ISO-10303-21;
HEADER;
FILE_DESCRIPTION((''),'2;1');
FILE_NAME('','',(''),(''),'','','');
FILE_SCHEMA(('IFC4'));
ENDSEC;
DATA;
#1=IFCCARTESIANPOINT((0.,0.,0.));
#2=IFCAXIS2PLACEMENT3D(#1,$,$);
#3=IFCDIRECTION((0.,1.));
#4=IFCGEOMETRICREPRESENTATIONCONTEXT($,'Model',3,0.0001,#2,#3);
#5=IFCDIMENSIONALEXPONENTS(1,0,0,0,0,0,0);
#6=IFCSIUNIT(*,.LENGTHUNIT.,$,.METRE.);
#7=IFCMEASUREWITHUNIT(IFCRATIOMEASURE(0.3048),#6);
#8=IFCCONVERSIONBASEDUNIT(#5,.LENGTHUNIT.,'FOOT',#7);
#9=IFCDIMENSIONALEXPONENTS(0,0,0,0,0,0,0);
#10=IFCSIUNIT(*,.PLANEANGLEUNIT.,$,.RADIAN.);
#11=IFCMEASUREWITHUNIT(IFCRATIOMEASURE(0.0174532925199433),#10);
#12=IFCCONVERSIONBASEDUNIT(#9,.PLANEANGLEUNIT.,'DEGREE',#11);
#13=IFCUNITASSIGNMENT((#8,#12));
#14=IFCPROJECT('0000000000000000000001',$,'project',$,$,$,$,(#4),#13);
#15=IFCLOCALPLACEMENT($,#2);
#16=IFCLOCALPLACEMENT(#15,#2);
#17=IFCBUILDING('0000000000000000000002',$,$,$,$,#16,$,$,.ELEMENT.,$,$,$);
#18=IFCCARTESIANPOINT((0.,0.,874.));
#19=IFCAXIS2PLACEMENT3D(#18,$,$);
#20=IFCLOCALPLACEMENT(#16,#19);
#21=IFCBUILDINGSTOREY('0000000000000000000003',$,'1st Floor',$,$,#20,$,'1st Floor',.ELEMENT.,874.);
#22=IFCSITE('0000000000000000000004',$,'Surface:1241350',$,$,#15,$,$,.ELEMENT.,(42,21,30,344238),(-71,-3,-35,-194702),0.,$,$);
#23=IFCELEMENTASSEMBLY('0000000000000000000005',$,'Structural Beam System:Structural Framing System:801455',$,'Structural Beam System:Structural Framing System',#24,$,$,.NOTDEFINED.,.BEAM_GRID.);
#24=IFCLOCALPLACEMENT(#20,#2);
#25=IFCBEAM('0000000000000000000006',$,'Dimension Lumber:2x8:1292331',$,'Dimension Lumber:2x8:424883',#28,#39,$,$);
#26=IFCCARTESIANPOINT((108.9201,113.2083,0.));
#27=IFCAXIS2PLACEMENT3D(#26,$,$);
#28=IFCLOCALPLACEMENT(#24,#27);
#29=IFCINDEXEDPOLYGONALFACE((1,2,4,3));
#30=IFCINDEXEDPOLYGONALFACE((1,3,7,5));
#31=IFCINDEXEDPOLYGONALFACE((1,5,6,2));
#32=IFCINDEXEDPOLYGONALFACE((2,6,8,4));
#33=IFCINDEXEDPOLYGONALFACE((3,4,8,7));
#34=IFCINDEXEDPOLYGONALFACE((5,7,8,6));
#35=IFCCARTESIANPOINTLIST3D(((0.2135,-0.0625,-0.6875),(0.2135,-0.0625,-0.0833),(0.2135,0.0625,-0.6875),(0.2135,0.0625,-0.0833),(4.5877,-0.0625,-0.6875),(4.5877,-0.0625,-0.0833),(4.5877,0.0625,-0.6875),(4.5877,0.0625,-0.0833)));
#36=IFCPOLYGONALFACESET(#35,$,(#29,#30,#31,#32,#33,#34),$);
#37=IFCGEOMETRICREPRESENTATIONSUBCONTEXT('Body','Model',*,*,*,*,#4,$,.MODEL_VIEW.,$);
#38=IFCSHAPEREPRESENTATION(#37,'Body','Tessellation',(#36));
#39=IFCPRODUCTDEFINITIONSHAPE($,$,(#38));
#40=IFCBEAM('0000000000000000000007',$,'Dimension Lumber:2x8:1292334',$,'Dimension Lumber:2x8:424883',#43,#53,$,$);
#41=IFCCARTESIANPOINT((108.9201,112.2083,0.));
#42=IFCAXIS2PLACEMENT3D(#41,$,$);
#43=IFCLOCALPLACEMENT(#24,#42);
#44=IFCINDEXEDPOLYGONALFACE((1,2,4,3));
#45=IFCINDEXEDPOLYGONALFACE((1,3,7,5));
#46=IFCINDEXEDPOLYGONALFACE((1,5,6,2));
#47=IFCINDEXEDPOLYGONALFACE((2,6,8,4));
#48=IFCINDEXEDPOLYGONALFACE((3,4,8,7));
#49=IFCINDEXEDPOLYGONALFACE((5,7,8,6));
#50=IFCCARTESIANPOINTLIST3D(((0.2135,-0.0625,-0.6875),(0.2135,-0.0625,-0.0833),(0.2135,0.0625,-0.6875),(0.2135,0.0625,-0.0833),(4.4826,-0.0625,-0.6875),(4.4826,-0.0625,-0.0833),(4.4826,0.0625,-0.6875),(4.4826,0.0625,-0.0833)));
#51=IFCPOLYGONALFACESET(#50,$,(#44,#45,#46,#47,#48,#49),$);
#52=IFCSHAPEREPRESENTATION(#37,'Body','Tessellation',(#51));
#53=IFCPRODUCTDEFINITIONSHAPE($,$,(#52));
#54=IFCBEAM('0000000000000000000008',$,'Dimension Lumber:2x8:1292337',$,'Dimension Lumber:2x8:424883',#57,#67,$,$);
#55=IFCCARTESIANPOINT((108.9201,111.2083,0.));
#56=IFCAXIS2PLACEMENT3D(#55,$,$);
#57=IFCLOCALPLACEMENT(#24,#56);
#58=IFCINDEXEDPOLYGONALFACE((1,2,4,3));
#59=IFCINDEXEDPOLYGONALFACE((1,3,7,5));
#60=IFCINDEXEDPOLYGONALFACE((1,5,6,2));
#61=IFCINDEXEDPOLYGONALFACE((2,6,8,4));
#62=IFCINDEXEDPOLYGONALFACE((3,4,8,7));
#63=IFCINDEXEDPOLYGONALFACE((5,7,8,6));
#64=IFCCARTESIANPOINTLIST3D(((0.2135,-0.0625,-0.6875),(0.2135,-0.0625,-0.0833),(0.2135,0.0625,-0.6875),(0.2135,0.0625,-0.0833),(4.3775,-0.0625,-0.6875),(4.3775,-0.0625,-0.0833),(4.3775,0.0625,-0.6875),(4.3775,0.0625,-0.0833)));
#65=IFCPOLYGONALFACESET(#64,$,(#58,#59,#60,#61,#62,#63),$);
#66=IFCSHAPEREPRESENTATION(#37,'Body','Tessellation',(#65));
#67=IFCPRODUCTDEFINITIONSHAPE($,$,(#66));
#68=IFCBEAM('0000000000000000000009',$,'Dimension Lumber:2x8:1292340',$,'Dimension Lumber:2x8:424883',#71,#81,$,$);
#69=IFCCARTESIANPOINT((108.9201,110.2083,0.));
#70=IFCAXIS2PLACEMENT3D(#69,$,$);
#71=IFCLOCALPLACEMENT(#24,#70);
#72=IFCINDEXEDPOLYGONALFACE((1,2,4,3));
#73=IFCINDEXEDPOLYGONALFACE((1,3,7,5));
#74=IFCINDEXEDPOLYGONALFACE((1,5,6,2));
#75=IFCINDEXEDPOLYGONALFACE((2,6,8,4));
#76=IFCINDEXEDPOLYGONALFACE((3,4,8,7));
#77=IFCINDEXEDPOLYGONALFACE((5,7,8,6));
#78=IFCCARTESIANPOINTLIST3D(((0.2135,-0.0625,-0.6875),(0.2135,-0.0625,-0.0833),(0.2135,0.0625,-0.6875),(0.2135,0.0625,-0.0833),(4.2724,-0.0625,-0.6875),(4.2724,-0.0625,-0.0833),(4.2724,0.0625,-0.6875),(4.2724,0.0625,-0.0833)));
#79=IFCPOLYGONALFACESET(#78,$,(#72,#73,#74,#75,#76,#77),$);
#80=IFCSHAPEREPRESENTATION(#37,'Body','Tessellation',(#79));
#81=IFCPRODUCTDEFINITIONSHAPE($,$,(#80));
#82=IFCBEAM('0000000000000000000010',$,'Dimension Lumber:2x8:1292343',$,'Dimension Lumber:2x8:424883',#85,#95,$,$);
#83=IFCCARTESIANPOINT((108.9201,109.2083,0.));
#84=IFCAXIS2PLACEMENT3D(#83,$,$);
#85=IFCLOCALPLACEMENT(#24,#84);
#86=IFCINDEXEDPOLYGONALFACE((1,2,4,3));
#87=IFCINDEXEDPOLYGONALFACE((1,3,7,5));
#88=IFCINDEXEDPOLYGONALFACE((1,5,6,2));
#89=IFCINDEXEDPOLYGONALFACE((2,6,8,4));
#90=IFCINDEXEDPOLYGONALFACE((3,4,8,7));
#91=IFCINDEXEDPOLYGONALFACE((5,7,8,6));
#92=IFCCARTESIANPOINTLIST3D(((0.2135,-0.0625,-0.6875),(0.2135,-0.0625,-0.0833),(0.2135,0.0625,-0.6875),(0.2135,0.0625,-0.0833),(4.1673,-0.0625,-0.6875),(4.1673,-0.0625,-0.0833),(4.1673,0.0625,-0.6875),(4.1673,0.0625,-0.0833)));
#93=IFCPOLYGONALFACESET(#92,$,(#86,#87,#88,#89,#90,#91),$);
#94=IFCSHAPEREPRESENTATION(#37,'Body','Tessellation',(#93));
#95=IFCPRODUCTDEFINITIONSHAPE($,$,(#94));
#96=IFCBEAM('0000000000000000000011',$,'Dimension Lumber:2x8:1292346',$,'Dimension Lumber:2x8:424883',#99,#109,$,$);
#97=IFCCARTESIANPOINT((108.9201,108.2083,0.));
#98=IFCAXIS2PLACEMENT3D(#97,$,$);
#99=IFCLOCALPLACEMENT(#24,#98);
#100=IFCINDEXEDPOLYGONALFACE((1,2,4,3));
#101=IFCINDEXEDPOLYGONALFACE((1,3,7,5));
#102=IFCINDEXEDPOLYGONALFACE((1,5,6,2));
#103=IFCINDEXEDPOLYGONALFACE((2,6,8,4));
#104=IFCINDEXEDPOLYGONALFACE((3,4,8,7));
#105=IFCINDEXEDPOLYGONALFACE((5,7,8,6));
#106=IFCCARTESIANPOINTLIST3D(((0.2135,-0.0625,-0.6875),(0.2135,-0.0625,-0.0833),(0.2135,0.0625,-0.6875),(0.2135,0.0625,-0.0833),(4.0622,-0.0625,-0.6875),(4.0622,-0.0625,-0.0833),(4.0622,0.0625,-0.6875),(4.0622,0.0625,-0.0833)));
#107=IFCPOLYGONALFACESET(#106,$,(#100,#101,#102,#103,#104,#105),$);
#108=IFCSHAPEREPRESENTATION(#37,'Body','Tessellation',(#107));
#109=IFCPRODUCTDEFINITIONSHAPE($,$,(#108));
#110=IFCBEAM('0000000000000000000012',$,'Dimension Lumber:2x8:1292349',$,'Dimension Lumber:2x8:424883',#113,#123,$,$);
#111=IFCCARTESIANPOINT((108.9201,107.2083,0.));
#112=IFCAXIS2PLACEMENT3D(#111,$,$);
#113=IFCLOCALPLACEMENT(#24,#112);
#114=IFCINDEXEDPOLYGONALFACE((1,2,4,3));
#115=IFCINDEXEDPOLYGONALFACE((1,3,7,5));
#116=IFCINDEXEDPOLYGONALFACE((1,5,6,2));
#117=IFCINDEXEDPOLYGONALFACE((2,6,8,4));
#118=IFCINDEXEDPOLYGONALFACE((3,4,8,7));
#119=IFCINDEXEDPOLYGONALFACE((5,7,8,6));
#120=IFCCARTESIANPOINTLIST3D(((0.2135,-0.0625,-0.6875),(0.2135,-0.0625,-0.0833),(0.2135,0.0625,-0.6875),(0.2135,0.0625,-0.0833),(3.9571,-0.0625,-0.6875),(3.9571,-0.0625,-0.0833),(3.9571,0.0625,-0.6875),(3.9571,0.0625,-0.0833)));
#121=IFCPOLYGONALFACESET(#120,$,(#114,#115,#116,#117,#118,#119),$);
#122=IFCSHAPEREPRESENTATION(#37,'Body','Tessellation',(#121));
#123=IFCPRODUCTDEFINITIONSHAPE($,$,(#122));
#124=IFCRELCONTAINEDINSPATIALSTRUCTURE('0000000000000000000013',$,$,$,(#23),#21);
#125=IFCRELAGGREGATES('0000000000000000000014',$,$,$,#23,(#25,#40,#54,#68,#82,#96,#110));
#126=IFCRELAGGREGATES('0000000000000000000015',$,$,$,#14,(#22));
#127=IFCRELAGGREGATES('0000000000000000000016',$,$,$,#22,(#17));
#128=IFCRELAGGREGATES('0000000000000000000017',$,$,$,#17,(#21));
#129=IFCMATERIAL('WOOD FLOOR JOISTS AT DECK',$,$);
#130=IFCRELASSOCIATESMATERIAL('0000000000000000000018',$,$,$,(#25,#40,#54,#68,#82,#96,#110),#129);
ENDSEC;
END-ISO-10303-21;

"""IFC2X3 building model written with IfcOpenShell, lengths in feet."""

from ifc_helpers import new_model, entity, si_unit, converted_unit, direction, frame, origin, origin_2d_with_axis, place, context, subcontext, project, spatial, rectangle, extrude, material, element, aggregate, save


model = new_model("IFC2X3")

# Units and contexts
model_context = context("Model", 3, precision=0.0001, world=origin(), true_north=direction((0.0, 1.0)))
body_context = subcontext(model_context, "Body", "Model", "MODEL_VIEW")
ifc_project = project(units=[converted_unit("LENGTHUNIT", "FOOT", entity("IfcRatioMeasure", 0.3048), si_unit("LENGTHUNIT", "METRE"), dimensions=[1, 0, 0, 0, 0, 0, 0]), converted_unit("PLANEANGLEUNIT", "DEGREE", entity("IfcRatioMeasure", 0.0174532925199433), si_unit("PLANEANGLEUNIT", "RADIAN"), dimensions=[0, 0, 0, 0, 0, 0, 0])], contexts=[model_context])

# Site, building, storey
site_placement = place(None, origin())
site = spatial("IfcSite", under=ifc_project, at=site_placement, Name="Surface:1241350", CompositionType="ELEMENT", RefLatitude=(42, 21, 30, 344238), RefLongitude=(-71, -3, -35, -194702), RefElevation=0.0)
building_placement = place(site_placement, origin())
building = spatial("IfcBuilding", under=site, at=building_placement, CompositionType="ELEMENT")
storey_placement = place(building_placement, frame((0.0, 0.0, 874.0)))
storey = spatial("IfcBuildingStorey", under=building, at=storey_placement, Name="1st Floor", LongName="1st Floor", CompositionType="ELEMENT", Elevation=874.0)

# Element assembly, beams
assembly_placement = place(storey_placement, origin())
assembly = element("IfcElementAssembly", 1, at=assembly_placement, inside=storey, Name="Structural Beam System:Structural Framing System:801455", ObjectType="Structural Beam System:Structural Framing System", AssemblyPlace="NOTDEFINED", PredefinedType="BEAM_GRID")
ifc_material_1 = material(Name="WOOD FLOOR JOISTS AT DECK")
beam_1_placement = place(assembly_placement, frame((108.9201, 113.2083, 0.0)))
beam_1 = element("IfcBeam", 2, at=beam_1_placement, material=ifc_material_1, Name="Dimension Lumber:2x8:1292331", ObjectType="Dimension Lumber:2x8:424883", context=body_context, shape_type="SweptSolid", body=[
    extrude(rectangle(XDim=0.6042, YDim=0.125, at=origin_2d_with_axis()), frame((0.2135, 0.0, -0.3854), z_axis=(1.0, 0.0, 0.0), x_axis=(0.0, 0.0, -1.0)), (0.0, 0.0, 1.0), 4.3742),
])
beam_2_placement = place(assembly_placement, frame((108.9201, 112.2083, 0.0)))
beam_2 = element("IfcBeam", 3, at=beam_2_placement, material=ifc_material_1, Name="Dimension Lumber:2x8:1292334", ObjectType="Dimension Lumber:2x8:424883", context=body_context, shape_type="SweptSolid", body=[
    extrude(rectangle(XDim=0.6042, YDim=0.125, at=origin_2d_with_axis()), frame((0.2135, 0.0, -0.3854), z_axis=(1.0, 0.0, 0.0), x_axis=(0.0, 0.0, -1.0)), (0.0, 0.0, 1.0), 4.2691),
])
beam_3_placement = place(assembly_placement, frame((108.9201, 111.2083, 0.0)))
beam_3 = element("IfcBeam", 4, at=beam_3_placement, material=ifc_material_1, Name="Dimension Lumber:2x8:1292337", ObjectType="Dimension Lumber:2x8:424883", context=body_context, shape_type="SweptSolid", body=[
    extrude(rectangle(XDim=0.6042, YDim=0.125, at=origin_2d_with_axis()), frame((0.2135, 0.0, -0.3854), z_axis=(1.0, 0.0, 0.0), x_axis=(0.0, 0.0, -1.0)), (0.0, 0.0, 1.0), 4.1639),
])
beam_4_placement = place(assembly_placement, frame((108.9201, 110.2083, 0.0)))
beam_4 = element("IfcBeam", 5, at=beam_4_placement, material=ifc_material_1, Name="Dimension Lumber:2x8:1292340", ObjectType="Dimension Lumber:2x8:424883", context=body_context, shape_type="SweptSolid", body=[
    extrude(rectangle(XDim=0.6042, YDim=0.125, at=origin_2d_with_axis()), frame((0.2135, 0.0, -0.3854), z_axis=(1.0, 0.0, 0.0), x_axis=(0.0, 0.0, -1.0)), (0.0, 0.0, 1.0), 4.0588),
])
beam_5_placement = place(assembly_placement, frame((108.9201, 109.2083, 0.0)))
beam_5 = element("IfcBeam", 6, at=beam_5_placement, material=ifc_material_1, Name="Dimension Lumber:2x8:1292343", ObjectType="Dimension Lumber:2x8:424883", context=body_context, shape_type="SweptSolid", body=[
    extrude(rectangle(XDim=0.6042, YDim=0.125, at=origin_2d_with_axis()), frame((0.2135, 0.0, -0.3854), z_axis=(1.0, 0.0, 0.0), x_axis=(0.0, 0.0, -1.0)), (0.0, 0.0, 1.0), 3.9537),
])
beam_6_placement = place(assembly_placement, frame((108.9201, 108.2083, 0.0)))
beam_6 = element("IfcBeam", 7, at=beam_6_placement, material=ifc_material_1, Name="Dimension Lumber:2x8:1292346", ObjectType="Dimension Lumber:2x8:424883", context=body_context, shape_type="SweptSolid", body=[
    extrude(rectangle(XDim=0.6042, YDim=0.125, at=origin_2d_with_axis()), frame((0.2135, 0.0, -0.3854), z_axis=(1.0, 0.0, 0.0), x_axis=(0.0, 0.0, -1.0)), (0.0, 0.0, 1.0), 3.8486),
])
beam_7_placement = place(assembly_placement, frame((108.9201, 107.2083, 0.0)))
beam_7 = element("IfcBeam", 8, at=beam_7_placement, material=ifc_material_1, Name="Dimension Lumber:2x8:1292349", ObjectType="Dimension Lumber:2x8:424883", context=body_context, shape_type="SweptSolid", body=[
    extrude(rectangle(XDim=0.6042, YDim=0.125, at=origin_2d_with_axis()), frame((0.2135, 0.0, -0.3854), z_axis=(1.0, 0.0, 0.0), x_axis=(0.0, 0.0, -1.0)), (0.0, 0.0, 1.0), 3.7435),
])
aggregate(assembly, [beam_1, beam_2, beam_3, beam_4, beam_5, beam_6, beam_7])

save(model, "model.ifc")
